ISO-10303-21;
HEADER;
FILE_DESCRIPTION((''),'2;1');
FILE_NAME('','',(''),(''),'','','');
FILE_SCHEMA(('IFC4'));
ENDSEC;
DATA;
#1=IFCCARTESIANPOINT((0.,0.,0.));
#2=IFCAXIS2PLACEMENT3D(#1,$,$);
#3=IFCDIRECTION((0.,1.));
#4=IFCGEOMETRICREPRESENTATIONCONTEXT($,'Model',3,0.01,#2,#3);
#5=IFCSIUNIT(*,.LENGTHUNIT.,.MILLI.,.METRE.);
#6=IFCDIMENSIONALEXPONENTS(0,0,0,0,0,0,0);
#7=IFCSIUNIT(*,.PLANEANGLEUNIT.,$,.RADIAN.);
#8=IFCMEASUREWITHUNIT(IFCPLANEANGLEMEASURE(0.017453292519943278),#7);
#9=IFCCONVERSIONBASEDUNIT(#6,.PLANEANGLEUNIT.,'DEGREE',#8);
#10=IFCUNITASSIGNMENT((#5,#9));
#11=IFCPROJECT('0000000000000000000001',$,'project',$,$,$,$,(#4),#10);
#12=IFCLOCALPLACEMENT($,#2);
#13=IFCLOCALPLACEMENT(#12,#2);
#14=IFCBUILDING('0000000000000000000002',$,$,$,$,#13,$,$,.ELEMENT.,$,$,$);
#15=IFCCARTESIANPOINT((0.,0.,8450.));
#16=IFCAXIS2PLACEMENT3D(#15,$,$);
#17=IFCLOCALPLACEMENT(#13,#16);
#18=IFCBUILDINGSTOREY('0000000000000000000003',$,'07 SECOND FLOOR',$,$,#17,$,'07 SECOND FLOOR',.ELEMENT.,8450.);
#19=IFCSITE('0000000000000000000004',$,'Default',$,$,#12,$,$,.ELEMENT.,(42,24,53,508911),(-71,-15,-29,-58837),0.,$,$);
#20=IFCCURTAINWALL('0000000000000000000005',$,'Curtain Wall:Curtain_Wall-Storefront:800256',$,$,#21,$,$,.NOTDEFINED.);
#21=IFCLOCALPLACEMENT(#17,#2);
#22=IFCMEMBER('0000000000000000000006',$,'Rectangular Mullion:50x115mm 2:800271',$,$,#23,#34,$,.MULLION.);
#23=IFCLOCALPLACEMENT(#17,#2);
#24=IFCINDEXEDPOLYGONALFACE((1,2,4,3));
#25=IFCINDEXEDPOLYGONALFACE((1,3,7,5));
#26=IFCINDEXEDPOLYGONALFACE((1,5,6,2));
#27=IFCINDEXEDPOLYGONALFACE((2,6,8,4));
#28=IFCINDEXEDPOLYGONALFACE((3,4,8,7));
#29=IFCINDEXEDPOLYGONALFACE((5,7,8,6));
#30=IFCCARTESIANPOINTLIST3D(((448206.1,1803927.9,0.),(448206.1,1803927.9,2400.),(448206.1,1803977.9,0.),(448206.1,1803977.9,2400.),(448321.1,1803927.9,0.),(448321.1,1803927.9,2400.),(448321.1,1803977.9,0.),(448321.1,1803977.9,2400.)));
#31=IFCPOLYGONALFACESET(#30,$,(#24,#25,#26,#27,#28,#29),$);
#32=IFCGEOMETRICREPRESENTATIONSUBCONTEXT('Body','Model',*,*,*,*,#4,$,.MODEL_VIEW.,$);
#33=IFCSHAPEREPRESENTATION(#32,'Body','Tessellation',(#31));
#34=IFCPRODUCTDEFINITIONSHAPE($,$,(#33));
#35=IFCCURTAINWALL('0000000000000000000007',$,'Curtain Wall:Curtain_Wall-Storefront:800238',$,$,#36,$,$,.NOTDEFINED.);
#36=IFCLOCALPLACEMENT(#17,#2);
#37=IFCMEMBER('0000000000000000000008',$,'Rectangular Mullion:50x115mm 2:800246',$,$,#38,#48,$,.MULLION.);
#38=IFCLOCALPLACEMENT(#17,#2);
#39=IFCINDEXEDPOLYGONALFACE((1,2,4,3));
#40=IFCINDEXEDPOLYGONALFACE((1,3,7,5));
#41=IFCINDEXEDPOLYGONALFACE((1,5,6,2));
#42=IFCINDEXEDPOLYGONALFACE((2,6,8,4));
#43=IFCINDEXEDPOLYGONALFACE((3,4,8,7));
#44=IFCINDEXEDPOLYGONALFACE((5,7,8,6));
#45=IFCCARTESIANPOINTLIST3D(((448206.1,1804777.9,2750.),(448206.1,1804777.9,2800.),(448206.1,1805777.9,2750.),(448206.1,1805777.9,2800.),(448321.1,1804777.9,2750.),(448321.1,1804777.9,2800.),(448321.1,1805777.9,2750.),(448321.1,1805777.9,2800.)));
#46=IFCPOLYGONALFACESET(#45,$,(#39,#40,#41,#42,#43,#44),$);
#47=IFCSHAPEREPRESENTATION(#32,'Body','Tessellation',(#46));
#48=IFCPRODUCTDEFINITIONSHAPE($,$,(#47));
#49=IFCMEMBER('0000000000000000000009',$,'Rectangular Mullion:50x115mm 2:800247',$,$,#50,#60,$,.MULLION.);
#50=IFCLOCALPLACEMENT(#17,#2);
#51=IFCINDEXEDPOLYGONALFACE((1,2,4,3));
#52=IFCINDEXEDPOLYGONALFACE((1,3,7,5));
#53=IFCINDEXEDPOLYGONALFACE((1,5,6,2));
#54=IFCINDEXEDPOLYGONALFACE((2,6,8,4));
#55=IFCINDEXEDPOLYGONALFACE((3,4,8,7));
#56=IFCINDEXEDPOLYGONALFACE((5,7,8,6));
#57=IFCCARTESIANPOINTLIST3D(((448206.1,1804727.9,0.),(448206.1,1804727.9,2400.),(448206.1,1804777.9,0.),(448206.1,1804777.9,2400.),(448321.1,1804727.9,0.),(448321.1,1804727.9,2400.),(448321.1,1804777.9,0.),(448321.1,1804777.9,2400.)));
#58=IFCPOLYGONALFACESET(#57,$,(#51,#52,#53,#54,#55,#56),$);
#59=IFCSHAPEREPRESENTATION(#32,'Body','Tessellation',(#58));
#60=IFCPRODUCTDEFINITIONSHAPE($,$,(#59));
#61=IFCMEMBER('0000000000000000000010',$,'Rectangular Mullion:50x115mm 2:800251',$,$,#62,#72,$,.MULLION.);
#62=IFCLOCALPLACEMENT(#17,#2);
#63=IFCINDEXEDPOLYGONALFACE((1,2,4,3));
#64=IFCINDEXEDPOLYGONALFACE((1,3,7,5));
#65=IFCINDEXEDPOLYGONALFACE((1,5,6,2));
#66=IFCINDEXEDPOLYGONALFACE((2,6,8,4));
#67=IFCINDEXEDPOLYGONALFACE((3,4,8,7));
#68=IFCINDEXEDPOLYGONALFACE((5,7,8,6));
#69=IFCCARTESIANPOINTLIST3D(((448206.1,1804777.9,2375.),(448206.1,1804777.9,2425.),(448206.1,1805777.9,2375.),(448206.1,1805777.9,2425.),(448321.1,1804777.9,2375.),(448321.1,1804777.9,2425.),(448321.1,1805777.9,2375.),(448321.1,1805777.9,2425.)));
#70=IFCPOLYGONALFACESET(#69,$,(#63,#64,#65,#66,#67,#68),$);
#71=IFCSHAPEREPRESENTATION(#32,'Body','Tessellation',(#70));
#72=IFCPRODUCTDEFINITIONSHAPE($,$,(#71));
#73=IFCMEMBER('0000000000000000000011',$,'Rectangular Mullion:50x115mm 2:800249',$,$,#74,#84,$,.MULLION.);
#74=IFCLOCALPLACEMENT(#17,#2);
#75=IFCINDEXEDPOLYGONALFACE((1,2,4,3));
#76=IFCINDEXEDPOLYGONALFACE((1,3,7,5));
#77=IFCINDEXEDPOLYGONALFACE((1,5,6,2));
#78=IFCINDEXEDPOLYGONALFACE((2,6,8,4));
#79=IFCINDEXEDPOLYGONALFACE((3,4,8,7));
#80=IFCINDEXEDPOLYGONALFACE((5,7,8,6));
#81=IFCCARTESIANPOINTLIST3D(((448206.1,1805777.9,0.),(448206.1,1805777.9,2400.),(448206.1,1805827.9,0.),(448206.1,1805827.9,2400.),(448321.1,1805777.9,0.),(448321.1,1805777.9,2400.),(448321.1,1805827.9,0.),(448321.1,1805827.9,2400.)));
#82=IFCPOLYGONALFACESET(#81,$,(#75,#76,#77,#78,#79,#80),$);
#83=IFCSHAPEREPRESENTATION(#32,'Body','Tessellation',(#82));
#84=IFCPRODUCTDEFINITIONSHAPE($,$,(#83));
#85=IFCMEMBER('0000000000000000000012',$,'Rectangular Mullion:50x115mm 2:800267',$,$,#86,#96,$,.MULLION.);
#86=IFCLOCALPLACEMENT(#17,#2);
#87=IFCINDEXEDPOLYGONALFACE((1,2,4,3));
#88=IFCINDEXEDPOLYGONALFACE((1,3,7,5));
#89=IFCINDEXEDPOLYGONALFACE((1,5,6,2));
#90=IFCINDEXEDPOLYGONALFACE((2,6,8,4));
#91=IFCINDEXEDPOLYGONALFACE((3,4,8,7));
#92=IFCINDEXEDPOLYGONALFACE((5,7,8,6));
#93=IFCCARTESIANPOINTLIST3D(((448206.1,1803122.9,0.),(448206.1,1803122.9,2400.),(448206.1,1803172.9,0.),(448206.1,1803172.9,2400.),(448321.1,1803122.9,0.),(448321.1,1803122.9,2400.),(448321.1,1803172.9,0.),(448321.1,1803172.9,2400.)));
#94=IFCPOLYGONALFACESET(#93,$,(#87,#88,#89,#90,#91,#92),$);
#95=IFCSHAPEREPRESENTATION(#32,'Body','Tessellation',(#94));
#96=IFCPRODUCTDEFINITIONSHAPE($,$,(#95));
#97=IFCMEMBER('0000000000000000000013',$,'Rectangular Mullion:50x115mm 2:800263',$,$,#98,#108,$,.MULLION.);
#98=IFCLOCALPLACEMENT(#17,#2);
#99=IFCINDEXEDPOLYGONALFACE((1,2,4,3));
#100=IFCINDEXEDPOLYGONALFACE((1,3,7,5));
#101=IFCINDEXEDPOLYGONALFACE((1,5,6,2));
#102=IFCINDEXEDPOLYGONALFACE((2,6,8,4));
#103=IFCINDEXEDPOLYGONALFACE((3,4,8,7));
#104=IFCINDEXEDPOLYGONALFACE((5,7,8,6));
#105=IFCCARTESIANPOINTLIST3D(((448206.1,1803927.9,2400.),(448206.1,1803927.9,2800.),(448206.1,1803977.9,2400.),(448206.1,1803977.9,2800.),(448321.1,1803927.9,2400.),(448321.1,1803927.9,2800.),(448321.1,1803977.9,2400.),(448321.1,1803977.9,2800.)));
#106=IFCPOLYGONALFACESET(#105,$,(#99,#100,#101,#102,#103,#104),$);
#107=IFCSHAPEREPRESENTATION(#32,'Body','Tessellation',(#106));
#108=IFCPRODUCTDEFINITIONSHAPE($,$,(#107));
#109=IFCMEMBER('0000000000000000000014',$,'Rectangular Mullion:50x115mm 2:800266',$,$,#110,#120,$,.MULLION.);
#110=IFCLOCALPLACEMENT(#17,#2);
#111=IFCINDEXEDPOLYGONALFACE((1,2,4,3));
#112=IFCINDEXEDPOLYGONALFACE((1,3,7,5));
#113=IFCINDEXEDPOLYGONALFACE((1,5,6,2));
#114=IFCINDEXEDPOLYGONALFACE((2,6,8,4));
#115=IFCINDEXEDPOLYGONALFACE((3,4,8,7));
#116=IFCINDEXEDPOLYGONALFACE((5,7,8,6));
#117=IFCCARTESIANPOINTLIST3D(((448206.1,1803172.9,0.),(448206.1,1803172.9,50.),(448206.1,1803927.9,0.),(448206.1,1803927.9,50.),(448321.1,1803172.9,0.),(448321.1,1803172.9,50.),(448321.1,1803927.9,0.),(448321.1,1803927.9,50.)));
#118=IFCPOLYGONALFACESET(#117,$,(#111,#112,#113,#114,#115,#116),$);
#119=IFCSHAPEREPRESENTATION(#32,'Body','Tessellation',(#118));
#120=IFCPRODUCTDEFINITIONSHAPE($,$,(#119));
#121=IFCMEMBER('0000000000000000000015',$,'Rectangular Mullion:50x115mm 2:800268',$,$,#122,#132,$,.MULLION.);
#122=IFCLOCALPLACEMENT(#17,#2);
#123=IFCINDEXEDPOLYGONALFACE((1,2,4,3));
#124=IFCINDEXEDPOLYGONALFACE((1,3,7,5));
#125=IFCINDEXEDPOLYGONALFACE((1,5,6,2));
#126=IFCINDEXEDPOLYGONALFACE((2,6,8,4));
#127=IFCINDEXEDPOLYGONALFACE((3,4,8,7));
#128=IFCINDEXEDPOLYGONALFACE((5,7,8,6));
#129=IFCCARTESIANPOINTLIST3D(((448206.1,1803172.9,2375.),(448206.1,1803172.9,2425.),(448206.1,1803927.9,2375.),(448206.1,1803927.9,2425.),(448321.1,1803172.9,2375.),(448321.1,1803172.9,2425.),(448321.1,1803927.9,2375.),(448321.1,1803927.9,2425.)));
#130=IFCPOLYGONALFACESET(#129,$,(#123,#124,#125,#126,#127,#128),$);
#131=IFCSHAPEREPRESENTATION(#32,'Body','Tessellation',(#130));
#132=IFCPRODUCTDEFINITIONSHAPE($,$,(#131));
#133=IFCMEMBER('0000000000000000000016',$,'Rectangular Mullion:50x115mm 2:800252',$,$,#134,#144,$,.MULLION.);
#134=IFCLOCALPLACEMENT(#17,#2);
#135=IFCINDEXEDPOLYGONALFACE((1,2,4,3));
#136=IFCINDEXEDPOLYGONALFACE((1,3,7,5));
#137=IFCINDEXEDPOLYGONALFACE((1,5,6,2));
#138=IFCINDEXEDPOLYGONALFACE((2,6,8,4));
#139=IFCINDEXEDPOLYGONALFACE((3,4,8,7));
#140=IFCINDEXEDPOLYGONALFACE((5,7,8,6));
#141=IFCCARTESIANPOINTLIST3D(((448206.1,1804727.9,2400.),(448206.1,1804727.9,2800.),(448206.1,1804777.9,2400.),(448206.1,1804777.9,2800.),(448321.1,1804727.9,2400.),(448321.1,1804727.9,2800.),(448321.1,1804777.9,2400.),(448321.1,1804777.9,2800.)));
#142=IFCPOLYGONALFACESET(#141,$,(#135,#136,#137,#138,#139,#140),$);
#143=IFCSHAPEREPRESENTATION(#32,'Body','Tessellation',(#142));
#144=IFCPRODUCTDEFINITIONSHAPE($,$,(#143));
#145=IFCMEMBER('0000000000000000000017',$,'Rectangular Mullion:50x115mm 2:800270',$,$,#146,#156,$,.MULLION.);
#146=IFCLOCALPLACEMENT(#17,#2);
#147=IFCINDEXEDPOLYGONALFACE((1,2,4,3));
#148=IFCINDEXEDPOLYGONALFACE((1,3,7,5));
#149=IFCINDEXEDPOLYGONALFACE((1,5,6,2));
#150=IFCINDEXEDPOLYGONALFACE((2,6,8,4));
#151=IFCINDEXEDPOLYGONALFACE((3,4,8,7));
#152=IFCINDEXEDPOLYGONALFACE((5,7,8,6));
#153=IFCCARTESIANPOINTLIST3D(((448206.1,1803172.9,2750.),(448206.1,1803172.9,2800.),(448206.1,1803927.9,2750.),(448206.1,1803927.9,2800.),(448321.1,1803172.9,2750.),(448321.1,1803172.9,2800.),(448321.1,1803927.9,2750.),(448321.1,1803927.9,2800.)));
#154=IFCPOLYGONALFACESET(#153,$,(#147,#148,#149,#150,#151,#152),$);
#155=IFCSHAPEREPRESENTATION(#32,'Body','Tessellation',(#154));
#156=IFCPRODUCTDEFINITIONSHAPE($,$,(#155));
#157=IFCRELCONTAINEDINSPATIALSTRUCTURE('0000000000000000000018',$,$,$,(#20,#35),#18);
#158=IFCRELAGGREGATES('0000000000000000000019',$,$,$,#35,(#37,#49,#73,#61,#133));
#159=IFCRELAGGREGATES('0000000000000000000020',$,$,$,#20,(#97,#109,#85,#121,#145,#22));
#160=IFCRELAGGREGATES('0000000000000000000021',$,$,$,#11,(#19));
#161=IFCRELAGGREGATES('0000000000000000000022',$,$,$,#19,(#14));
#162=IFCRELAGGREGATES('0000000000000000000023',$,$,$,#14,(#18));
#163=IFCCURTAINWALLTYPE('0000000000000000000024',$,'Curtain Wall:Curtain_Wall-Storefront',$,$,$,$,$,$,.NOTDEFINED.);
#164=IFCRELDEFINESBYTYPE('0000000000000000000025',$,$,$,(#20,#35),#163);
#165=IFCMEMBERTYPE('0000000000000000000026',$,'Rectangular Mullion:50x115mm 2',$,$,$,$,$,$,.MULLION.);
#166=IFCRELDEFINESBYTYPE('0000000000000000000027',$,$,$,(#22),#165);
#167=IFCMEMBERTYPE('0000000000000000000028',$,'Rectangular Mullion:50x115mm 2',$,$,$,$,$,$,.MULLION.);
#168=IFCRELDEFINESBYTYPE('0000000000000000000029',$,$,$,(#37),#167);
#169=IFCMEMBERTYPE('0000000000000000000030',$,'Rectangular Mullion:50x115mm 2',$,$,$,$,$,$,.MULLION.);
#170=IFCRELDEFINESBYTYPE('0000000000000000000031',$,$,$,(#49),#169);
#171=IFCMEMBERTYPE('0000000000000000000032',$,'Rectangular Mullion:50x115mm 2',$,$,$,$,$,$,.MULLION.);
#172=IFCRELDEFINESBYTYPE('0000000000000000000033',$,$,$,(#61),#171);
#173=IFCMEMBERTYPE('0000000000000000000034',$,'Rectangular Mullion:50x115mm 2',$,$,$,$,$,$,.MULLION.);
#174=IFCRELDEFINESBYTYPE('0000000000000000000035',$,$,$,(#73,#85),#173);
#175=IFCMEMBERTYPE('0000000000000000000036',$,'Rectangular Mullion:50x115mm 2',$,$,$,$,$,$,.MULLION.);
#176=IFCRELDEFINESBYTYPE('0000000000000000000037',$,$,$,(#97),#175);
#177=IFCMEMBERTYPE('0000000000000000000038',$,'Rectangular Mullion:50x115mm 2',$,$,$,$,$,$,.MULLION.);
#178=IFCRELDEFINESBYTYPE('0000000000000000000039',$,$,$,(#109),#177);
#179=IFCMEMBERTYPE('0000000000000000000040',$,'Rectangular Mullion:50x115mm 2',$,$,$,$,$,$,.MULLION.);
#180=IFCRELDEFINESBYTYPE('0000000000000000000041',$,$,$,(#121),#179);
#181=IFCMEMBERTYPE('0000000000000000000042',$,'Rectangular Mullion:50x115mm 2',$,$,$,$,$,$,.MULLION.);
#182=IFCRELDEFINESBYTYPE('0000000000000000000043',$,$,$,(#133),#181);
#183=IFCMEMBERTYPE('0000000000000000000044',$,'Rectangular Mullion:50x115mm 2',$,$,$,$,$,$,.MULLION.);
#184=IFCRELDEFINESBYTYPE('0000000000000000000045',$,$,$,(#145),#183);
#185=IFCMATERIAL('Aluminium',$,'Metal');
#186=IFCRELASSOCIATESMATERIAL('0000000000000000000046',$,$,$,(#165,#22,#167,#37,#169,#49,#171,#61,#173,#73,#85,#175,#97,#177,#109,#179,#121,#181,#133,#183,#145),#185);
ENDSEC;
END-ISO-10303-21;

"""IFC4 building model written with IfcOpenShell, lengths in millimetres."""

from ifc_helpers import new_model, entity, si_unit, converted_unit, direction, frame, origin, place, context, subcontext, project, spatial, indexed_curve, outline, extrude, source, transform, mapped, material, type_object, type_shapes, element, aggregate, save


model = new_model("IFC4")

# Units and contexts
model_context = context("Model", 3, precision=0.01, world=origin(), true_north=direction((0.0, 1.0)))
body_context = subcontext(model_context, "Body", "Model", "MODEL_VIEW")
ifc_project = project(units=[si_unit("LENGTHUNIT", "METRE", prefix="MILLI"), converted_unit("PLANEANGLEUNIT", "DEGREE", entity("IfcPlaneAngleMeasure", 0.017453292519943278), si_unit("PLANEANGLEUNIT", "RADIAN"), dimensions=[0, 0, 0, 0, 0, 0, 0])], contexts=[model_context])

# Site, building, storey
site_placement = place(None, origin())
site = spatial("IfcSite", under=ifc_project, at=site_placement, Name="Default", CompositionType="ELEMENT", RefLatitude=(42, 24, 53, 508911), RefLongitude=(-71, -15, -29, -58837), RefElevation=0.0)
building_placement = place(site_placement, origin())
building = spatial("IfcBuilding", under=site, at=building_placement, CompositionType="ELEMENT")
storey_placement = place(building_placement, frame((0.0, 0.0, 8450.0)))
storey = spatial("IfcBuildingStorey", under=building, at=storey_placement, Name="07 SECOND FLOOR", LongName="07 SECOND FLOOR", CompositionType="ELEMENT", Elevation=8450.0)

# Curtain wall, member
curtain_wall_type = type_object("IfcCurtainWallType", Name="Curtain Wall:Curtain_Wall-Storefront", PredefinedType="NOTDEFINED")
curtain_wall_1_placement = place(storey_placement, frame((0.0, 0.0, -8450.0)))
curtain_wall_1 = element("IfcCurtainWall", 1, at=curtain_wall_1_placement, inside=storey, type_object=curtain_wall_type, Name="Curtain Wall:Curtain_Wall-Storefront:800256", PredefinedType="NOTDEFINED")
ifc_material_1 = material(Name="Aluminium", Category="Metal")
member_type_1 = type_object("IfcMemberType", Name="Rectangular Mullion:50x115mm 2", PredefinedType="MULLION", material=ifc_material_1)
shared_shape_1 = source(origin(), body_context, "Body", "SweptSolid", [
    extrude(outline(indexed_curve([(-25.0, -57.5), (25.0, -57.5), (25.0, 57.5), (-25.0, 57.5), (-25.0, -57.5)], self_intersect=False)), frame((-25.0, 0.0, -2400.0), z_axis=(0.0, 0.0, 1.0), x_axis=(-1.0, 0.0, 0.0)), (0.0, 0.0, 1.0), 2400.0),
])
type_shapes(member_type_1, [shared_shape_1])
member_1_placement = place(curtain_wall_1_placement, frame((448263.6, 1803977.9, 10850.0), z_axis=(0.0, 0.0, 1.0), x_axis=(0.0, 1.0, 0.0)))
member_1 = element("IfcMember", 2, at=member_1_placement, type_object=member_type_1, material=ifc_material_1, Name="Rectangular Mullion:50x115mm 2:800271", PredefinedType="MULLION", context=body_context, shape_type="MappedRepresentation", body=[
    mapped(shared_shape_1, transform((0.0, 0.0, 0.0), scale=1.0)),
])

# Curtain wall, members
curtain_wall_2_placement = place(storey_placement, frame((0.0, 0.0, -8450.0)))
curtain_wall_2 = element("IfcCurtainWall", 3, at=curtain_wall_2_placement, inside=storey, type_object=curtain_wall_type, Name="Curtain Wall:Curtain_Wall-Storefront:800238", PredefinedType="NOTDEFINED")
member_type_2 = type_object("IfcMemberType", Name="Rectangular Mullion:50x115mm 2", PredefinedType="MULLION", material=ifc_material_1)
shared_shape_2 = source(origin(), body_context, "Body", "SweptSolid", [
    extrude(outline(indexed_curve([(-25.0, -57.5), (25.0, -57.5), (25.0, 57.5), (-25.0, 57.5), (-25.0, -57.5)], self_intersect=False)), frame((-25.0, 0.0, -1000.0), z_axis=(0.0, 0.0, 1.0), x_axis=(-1.0, 0.0, 0.0)), (0.0, 0.0, 1.0), 1000.0),
])
type_shapes(member_type_2, [shared_shape_2])
member_2_placement = place(curtain_wall_2_placement, frame((448263.6, 1804777.9, 11250.0), z_axis=(0.0, -1.0, 0.0), x_axis=(0.0, 0.0, 1.0)))
member_2 = element("IfcMember", 4, at=member_2_placement, type_object=member_type_2, material=ifc_material_1, Name="Rectangular Mullion:50x115mm 2:800246", PredefinedType="MULLION", context=body_context, shape_type="MappedRepresentation", body=[
    mapped(shared_shape_2, transform((0.0, 0.0, 0.0), scale=1.0)),
])
member_type_3 = type_object("IfcMemberType", Name="Rectangular Mullion:50x115mm 2", PredefinedType="MULLION", material=ifc_material_1)
shared_shape_3 = source(origin(), body_context, "Body", "SweptSolid", [
    extrude(outline(indexed_curve([(-25.0, -57.5), (25.0, -57.5), (25.0, 57.5), (-25.0, 57.5), (-25.0, -57.5)], self_intersect=False)), frame((-25.0, 0.0, -2400.0), z_axis=(0.0, 0.0, 1.0), x_axis=(-1.0, 0.0, 0.0)), (0.0, 0.0, 1.0), 2400.0),
])
type_shapes(member_type_3, [shared_shape_3])
member_3_placement = place(curtain_wall_2_placement, frame((448263.6, 1804727.9, 8450.0), z_axis=(0.0, 0.0, -1.0), x_axis=(0.0, -1.0, 0.0)))
member_3 = element("IfcMember", 5, at=member_3_placement, type_object=member_type_3, material=ifc_material_1, Name="Rectangular Mullion:50x115mm 2:800247", PredefinedType="MULLION", context=body_context, shape_type="MappedRepresentation", body=[
    mapped(shared_shape_3, transform((0.0, 0.0, 0.0), scale=1.0)),
])
member_type_4 = type_object("IfcMemberType", Name="Rectangular Mullion:50x115mm 2", PredefinedType="MULLION", material=ifc_material_1)
shared_shape_4 = source(origin(), body_context, "Body", "SweptSolid", [
    extrude(outline(indexed_curve([(-25.0, -57.5), (25.0, -57.5), (25.0, 57.5), (-25.0, 57.5), (-25.0, -57.5)], self_intersect=False)), frame((0.0, 0.0, -1000.0), z_axis=(0.0, 0.0, 1.0), x_axis=(-1.0, 0.0, 0.0)), (0.0, 0.0, 1.0), 1000.0),
])
type_shapes(member_type_4, [shared_shape_4])
member_4_placement = place(curtain_wall_2_placement, frame((448263.6, 1804777.9, 10850.0), z_axis=(0.0, -1.0, 0.0), x_axis=(0.0, 0.0, 1.0)))
member_4 = element("IfcMember", 6, at=member_4_placement, type_object=member_type_4, material=ifc_material_1, Name="Rectangular Mullion:50x115mm 2:800251", PredefinedType="MULLION", context=body_context, shape_type="MappedRepresentation", body=[
    mapped(shared_shape_4, transform((0.0, 0.0, 0.0), scale=1.0)),
])
member_type_5 = type_object("IfcMemberType", Name="Rectangular Mullion:50x115mm 2", PredefinedType="MULLION", material=ifc_material_1)
shared_shape_5 = source(origin(), body_context, "Body", "SweptSolid", [
    extrude(outline(indexed_curve([(-25.0, -57.5), (25.0, -57.5), (25.0, 57.5), (-25.0, 57.5), (-25.0, -57.5)], self_intersect=False)), frame((0.0, 0.0, -2400.0), z_axis=(0.0, 0.0, 1.0), x_axis=(-1.0, 0.0, 0.0)), (0.0, 0.0, 1.0), 2400.0),
])
type_shapes(member_type_5, [shared_shape_5])
member_5_placement = place(curtain_wall_2_placement, frame((448263.6, 1805802.9, 8450.0), z_axis=(0.0, 0.0, -1.0), x_axis=(0.0, -1.0, 0.0)))
member_5 = element("IfcMember", 7, at=member_5_placement, type_object=member_type_5, material=ifc_material_1, Name="Rectangular Mullion:50x115mm 2:800249", PredefinedType="MULLION", context=body_context, shape_type="MappedRepresentation", body=[
    mapped(shared_shape_5, transform((0.0, 0.0, 0.0), scale=1.0)),
])

# Members
member_6_placement = place(curtain_wall_1_placement, frame((448263.6, 1803147.9, 8450.0), z_axis=(0.0, 0.0, -1.0), x_axis=(0.0, -1.0, 0.0)))
member_6 = element("IfcMember", 8, at=member_6_placement, type_object=member_type_5, material=ifc_material_1, Name="Rectangular Mullion:50x115mm 2:800267", PredefinedType="MULLION", context=body_context, shape_type="MappedRepresentation", body=[
    mapped(shared_shape_5, transform((0.0, 0.0, 0.0), scale=1.0)),
])
member_type_6 = type_object("IfcMemberType", Name="Rectangular Mullion:50x115mm 2", PredefinedType="MULLION", material=ifc_material_1)
shared_shape_6 = source(origin(), body_context, "Body", "SweptSolid", [
    extrude(outline(indexed_curve([(-25.0, -57.5), (25.0, -57.5), (25.0, 57.5), (-25.0, 57.5), (-25.0, -57.5)], self_intersect=False)), frame((-25.0, 0.0, -400.0), z_axis=(0.0, 0.0, 1.0), x_axis=(-1.0, 0.0, 0.0)), (0.0, 0.0, 1.0), 400.0),
])
type_shapes(member_type_6, [shared_shape_6])
member_7_placement = place(curtain_wall_1_placement, frame((448263.6, 1803977.9, 11250.0), z_axis=(0.0, 0.0, 1.0), x_axis=(0.0, 1.0, 0.0)))
member_7 = element("IfcMember", 9, at=member_7_placement, type_object=member_type_6, material=ifc_material_1, Name="Rectangular Mullion:50x115mm 2:800263", PredefinedType="MULLION", context=body_context, shape_type="MappedRepresentation", body=[
    mapped(shared_shape_6, transform((0.0, 0.0, 0.0), scale=1.0)),
])
member_type_7 = type_object("IfcMemberType", Name="Rectangular Mullion:50x115mm 2", PredefinedType="MULLION", material=ifc_material_1)
shared_shape_7 = source(origin(), body_context, "Body", "SweptSolid", [
    extrude(outline(indexed_curve([(-25.0, -57.5), (25.0, -57.5), (25.0, 57.5), (-25.0, 57.5), (-25.0, -57.5)], self_intersect=False)), frame((-25.0, 0.0, -755.0), z_axis=(0.0, 0.0, 1.0), x_axis=(-1.0, 0.0, 0.0)), (0.0, 0.0, 1.0), 755.0),
])
type_shapes(member_type_7, [shared_shape_7])
member_8_placement = place(curtain_wall_1_placement, frame((448263.6, 1803927.9, 8450.0), z_axis=(0.0, 1.0, 0.0), x_axis=(0.0, 0.0, -1.0)))
member_8 = element("IfcMember", 10, at=member_8_placement, type_object=member_type_7, material=ifc_material_1, Name="Rectangular Mullion:50x115mm 2:800266", PredefinedType="MULLION", context=body_context, shape_type="MappedRepresentation", body=[
    mapped(shared_shape_7, transform((0.0, 0.0, 0.0), scale=1.0)),
])
member_type_8 = type_object("IfcMemberType", Name="Rectangular Mullion:50x115mm 2", PredefinedType="MULLION", material=ifc_material_1)
shared_shape_8 = source(origin(), body_context, "Body", "SweptSolid", [
    extrude(outline(indexed_curve([(-25.0, -57.5), (25.0, -57.5), (25.0, 57.5), (-25.0, 57.5), (-25.0, -57.5)], self_intersect=False)), frame((0.0, 0.0, -755.0), z_axis=(0.0, 0.0, 1.0), x_axis=(-1.0, 0.0, 0.0)), (0.0, 0.0, 1.0), 755.0),
])
type_shapes(member_type_8, [shared_shape_8])
member_9_placement = place(curtain_wall_1_placement, frame((448263.6, 1803172.9, 10850.0), z_axis=(0.0, -1.0, 0.0), x_axis=(0.0, 0.0, 1.0)))
member_9 = element("IfcMember", 11, at=member_9_placement, type_object=member_type_8, material=ifc_material_1, Name="Rectangular Mullion:50x115mm 2:800268", PredefinedType="MULLION", context=body_context, shape_type="MappedRepresentation", body=[
    mapped(shared_shape_8, transform((0.0, 0.0, 0.0), scale=1.0)),
])
member_type_9 = type_object("IfcMemberType", Name="Rectangular Mullion:50x115mm 2", PredefinedType="MULLION", material=ifc_material_1)
shared_shape_9 = source(origin(), body_context, "Body", "SweptSolid", [
    extrude(outline(indexed_curve([(-25.0, -57.5), (25.0, -57.5), (25.0, 57.5), (-25.0, 57.5), (-25.0, -57.5)], self_intersect=False)), frame((-25.0, 0.0, -400.0), z_axis=(0.0, 0.0, 1.0), x_axis=(-1.0, 0.0, 0.0)), (0.0, 0.0, 1.0), 400.0),
])
type_shapes(member_type_9, [shared_shape_9])
member_10_placement = place(curtain_wall_2_placement, frame((448263.6, 1804727.9, 10850.0), z_axis=(0.0, 0.0, -1.0), x_axis=(0.0, -1.0, 0.0)))
member_10 = element("IfcMember", 12, at=member_10_placement, type_object=member_type_9, material=ifc_material_1, Name="Rectangular Mullion:50x115mm 2:800252", PredefinedType="MULLION", context=body_context, shape_type="MappedRepresentation", body=[
    mapped(shared_shape_9, transform((0.0, 0.0, 0.0), scale=1.0)),
])
member_type_10 = type_object("IfcMemberType", Name="Rectangular Mullion:50x115mm 2", PredefinedType="MULLION", material=ifc_material_1)
shared_shape_10 = source(origin(), body_context, "Body", "SweptSolid", [
    extrude(outline(indexed_curve([(-25.0, -57.5), (25.0, -57.5), (25.0, 57.5), (-25.0, 57.5), (-25.0, -57.5)], self_intersect=False)), frame((-25.0, 0.0, -755.0), z_axis=(0.0, 0.0, 1.0), x_axis=(-1.0, 0.0, 0.0)), (0.0, 0.0, 1.0), 755.0),
])
type_shapes(member_type_10, [shared_shape_10])
member_11_placement = place(curtain_wall_1_placement, frame((448263.6, 1803172.9, 11250.0), z_axis=(0.0, -1.0, 0.0), x_axis=(0.0, 0.0, 1.0)))
member_11 = element("IfcMember", 13, at=member_11_placement, type_object=member_type_10, material=ifc_material_1, Name="Rectangular Mullion:50x115mm 2:800270", PredefinedType="MULLION", context=body_context, shape_type="MappedRepresentation", body=[
    mapped(shared_shape_10, transform((0.0, 0.0, 0.0), scale=1.0)),
])

aggregate(curtain_wall_2, [member_2, member_3, member_5, member_4, member_10])
aggregate(curtain_wall_1, [member_7, member_8, member_6, member_9, member_11, member_1])

save(model, "model.ifc")
